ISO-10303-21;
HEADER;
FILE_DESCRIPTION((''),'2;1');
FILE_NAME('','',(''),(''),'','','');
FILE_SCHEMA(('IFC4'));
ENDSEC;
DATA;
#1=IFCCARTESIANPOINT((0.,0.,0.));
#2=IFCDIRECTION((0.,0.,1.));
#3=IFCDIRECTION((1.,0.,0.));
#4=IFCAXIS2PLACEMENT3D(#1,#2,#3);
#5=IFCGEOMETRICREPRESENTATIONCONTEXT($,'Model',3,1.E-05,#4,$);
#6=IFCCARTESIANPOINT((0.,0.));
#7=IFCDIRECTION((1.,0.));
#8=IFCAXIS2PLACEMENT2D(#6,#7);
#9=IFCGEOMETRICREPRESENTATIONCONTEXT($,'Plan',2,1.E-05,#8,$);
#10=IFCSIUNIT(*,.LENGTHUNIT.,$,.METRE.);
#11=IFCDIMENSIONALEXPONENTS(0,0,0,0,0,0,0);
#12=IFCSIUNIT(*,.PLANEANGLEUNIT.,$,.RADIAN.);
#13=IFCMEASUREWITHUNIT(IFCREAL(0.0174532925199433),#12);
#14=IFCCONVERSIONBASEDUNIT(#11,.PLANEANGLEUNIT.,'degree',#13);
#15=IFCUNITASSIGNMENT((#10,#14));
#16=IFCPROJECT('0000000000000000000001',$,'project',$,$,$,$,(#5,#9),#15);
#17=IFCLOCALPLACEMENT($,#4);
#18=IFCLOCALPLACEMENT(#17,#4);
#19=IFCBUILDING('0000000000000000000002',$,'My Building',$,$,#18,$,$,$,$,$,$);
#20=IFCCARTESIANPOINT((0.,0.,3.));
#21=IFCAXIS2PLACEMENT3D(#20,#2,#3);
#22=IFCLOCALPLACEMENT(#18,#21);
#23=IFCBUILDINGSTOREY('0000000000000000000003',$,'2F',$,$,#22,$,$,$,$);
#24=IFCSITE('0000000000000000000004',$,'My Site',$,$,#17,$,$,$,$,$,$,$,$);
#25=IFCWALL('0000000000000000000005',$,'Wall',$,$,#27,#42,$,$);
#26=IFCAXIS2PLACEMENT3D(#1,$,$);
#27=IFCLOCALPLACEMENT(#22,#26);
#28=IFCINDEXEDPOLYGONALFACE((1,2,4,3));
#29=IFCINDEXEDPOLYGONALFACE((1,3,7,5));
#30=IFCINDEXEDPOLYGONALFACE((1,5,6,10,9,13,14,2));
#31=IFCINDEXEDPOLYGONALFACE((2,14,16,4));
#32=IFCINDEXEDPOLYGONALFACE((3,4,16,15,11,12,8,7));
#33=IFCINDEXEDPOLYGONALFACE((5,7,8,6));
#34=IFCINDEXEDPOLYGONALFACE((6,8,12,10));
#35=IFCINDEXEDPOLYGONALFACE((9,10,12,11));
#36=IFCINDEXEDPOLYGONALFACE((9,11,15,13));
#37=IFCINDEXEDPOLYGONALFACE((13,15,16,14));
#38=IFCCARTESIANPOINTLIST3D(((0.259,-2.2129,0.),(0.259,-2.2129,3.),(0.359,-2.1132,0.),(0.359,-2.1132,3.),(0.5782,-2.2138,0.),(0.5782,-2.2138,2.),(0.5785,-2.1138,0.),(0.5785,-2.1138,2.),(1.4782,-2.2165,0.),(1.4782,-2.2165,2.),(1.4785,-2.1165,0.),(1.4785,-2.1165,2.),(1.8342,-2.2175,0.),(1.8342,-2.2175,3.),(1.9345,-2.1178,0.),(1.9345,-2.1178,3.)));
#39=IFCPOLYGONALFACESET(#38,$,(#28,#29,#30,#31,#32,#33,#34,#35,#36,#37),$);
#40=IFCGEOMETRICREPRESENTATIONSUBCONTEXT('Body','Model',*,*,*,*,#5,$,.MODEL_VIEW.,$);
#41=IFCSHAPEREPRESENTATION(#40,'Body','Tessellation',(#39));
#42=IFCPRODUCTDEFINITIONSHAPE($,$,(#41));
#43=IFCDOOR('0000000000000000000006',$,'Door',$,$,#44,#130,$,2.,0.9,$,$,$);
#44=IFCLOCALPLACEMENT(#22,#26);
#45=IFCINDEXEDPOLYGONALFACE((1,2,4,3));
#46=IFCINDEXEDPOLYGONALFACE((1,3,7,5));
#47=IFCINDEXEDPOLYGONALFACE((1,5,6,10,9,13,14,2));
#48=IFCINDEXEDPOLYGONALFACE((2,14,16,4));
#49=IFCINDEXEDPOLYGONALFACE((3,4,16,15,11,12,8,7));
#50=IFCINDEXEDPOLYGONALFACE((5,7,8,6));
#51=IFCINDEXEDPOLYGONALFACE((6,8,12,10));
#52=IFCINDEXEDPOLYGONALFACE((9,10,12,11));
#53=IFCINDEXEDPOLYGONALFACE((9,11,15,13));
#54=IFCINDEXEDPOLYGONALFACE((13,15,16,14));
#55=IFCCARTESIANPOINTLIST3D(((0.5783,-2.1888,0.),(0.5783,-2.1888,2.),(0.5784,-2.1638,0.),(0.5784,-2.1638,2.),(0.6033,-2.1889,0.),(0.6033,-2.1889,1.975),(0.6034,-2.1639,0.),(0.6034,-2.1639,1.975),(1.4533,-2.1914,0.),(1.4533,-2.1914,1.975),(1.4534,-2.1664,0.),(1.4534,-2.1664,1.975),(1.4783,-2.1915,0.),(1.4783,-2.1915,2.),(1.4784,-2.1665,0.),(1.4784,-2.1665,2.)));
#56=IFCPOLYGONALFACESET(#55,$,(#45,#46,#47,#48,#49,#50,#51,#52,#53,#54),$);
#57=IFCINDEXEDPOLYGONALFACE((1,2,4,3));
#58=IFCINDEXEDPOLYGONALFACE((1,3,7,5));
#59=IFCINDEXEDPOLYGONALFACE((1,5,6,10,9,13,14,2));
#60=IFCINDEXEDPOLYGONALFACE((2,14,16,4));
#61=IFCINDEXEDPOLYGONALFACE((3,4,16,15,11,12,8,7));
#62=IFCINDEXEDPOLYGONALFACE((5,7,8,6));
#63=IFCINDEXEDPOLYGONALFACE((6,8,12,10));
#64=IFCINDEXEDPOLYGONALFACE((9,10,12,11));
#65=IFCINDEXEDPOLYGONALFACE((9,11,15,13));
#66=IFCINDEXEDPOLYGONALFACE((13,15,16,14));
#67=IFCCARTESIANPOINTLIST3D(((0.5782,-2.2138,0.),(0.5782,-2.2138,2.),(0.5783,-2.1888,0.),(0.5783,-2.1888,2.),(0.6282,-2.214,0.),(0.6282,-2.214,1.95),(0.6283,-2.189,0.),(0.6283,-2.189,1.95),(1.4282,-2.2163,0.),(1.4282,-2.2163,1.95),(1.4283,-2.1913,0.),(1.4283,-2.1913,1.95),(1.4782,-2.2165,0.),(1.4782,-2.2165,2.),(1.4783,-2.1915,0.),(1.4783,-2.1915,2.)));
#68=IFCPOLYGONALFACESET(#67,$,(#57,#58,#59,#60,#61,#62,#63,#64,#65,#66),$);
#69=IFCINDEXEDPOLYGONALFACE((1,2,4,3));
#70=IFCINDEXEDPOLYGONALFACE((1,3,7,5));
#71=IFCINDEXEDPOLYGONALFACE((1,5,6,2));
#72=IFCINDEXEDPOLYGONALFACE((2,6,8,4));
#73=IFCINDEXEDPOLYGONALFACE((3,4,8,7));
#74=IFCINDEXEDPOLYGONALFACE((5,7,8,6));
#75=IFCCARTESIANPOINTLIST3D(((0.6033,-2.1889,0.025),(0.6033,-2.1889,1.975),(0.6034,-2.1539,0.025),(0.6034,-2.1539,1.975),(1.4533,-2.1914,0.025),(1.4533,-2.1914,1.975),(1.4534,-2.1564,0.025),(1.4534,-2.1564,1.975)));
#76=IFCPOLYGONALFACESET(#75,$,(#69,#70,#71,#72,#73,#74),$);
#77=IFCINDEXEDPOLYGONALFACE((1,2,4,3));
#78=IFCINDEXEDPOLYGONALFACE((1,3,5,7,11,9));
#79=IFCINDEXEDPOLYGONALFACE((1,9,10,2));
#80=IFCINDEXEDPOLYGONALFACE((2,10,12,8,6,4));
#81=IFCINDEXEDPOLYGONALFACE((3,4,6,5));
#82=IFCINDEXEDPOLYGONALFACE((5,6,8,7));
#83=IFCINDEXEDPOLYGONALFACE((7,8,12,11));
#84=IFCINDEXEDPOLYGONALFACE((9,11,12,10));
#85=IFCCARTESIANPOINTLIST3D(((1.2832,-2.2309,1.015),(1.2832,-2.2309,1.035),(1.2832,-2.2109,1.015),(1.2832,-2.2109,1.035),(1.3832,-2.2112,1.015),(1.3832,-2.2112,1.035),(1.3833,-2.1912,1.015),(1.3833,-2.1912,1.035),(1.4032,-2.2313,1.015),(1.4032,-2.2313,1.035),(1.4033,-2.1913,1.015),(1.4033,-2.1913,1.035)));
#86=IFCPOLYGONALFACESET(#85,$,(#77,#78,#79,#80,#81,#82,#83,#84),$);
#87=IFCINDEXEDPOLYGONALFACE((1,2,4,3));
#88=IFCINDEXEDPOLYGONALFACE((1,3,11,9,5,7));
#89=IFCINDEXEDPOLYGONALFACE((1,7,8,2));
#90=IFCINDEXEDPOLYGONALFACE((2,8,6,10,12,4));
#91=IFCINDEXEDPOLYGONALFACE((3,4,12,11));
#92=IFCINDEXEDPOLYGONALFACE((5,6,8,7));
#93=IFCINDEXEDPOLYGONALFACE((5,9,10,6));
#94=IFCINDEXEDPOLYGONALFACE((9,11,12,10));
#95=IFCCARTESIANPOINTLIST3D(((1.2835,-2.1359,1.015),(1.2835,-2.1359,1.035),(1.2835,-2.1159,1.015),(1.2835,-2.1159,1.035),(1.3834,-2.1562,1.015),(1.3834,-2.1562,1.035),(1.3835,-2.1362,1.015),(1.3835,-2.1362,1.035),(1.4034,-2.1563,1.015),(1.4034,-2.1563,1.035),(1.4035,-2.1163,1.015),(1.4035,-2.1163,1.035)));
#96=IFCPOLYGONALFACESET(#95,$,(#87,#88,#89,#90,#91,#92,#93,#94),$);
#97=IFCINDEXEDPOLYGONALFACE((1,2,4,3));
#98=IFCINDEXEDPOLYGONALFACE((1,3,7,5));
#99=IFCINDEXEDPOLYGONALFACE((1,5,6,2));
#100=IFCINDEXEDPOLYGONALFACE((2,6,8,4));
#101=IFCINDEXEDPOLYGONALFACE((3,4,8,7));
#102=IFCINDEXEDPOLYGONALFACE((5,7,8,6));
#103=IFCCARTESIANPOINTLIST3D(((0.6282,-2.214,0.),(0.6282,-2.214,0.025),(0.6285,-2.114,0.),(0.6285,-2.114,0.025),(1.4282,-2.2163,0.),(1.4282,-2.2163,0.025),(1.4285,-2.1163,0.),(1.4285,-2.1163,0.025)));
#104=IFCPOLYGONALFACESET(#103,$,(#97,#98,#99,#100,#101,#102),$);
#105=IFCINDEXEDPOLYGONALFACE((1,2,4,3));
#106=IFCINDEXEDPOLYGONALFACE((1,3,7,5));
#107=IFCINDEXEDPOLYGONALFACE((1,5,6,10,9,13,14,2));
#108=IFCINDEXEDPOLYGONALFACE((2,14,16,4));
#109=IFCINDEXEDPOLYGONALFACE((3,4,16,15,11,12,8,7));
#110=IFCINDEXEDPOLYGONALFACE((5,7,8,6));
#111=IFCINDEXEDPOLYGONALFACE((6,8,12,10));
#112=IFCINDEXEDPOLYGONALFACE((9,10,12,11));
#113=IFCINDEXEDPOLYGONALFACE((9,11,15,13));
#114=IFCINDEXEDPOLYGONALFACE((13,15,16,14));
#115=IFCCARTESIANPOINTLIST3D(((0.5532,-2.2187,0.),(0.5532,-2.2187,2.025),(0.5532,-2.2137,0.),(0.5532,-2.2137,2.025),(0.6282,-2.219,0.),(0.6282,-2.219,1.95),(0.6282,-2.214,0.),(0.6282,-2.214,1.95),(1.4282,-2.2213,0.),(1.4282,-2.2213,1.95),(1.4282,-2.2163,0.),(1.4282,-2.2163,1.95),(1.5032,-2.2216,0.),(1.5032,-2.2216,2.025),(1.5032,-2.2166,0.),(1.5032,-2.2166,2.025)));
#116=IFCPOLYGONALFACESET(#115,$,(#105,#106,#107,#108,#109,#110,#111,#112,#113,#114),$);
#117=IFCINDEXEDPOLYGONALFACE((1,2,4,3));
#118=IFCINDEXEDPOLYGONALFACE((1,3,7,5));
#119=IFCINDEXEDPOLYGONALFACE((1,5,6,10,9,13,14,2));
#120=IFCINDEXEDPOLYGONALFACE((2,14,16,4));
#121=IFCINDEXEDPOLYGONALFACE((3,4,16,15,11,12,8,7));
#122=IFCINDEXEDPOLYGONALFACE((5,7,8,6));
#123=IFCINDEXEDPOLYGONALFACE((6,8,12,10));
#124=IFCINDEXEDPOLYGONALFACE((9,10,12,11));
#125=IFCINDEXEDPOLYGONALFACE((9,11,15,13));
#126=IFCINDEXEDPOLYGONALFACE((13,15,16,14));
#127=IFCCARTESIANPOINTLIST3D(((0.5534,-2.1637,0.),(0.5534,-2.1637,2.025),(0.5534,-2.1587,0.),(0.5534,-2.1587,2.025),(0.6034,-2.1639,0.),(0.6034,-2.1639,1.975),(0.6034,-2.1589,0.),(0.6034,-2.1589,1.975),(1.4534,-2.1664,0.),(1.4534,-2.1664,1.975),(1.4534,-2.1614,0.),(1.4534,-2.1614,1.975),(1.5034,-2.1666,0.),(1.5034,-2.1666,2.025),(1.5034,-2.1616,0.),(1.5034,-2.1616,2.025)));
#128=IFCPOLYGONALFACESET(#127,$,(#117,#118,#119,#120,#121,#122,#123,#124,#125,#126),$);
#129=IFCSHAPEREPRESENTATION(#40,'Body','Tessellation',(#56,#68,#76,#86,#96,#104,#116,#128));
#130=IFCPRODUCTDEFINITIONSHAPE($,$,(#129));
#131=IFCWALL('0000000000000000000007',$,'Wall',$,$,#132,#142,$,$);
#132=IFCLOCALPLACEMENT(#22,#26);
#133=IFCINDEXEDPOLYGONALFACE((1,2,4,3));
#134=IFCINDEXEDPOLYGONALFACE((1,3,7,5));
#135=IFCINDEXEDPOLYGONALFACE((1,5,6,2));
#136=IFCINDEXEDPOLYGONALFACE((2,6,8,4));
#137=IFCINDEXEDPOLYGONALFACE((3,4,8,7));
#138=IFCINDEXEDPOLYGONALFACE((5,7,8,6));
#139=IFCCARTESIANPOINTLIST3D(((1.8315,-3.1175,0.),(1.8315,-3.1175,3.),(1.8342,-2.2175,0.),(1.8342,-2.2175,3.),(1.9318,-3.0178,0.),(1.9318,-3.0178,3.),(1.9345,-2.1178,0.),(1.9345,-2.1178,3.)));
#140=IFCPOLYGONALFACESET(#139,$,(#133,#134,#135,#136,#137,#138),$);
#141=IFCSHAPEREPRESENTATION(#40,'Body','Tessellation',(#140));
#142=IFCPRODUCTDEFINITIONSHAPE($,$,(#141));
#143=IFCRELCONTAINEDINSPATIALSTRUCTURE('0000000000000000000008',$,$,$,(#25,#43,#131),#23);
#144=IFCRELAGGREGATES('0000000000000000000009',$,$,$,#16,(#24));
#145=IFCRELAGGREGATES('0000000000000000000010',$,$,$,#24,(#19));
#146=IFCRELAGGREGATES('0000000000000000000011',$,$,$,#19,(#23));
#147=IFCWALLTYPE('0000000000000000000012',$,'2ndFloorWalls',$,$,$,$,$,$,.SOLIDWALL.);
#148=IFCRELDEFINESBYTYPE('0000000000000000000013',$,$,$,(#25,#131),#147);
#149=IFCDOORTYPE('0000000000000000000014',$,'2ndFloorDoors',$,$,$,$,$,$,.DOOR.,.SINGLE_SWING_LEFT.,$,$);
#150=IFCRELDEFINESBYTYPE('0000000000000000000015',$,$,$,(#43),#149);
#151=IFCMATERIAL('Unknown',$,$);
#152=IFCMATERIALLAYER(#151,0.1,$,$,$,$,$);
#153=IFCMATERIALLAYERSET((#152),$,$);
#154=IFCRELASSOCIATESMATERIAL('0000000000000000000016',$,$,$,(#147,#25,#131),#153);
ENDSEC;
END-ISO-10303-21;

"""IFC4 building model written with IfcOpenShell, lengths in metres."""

from ifc_helpers import new_model, entity, si_unit, converted_unit, frame, origin_with_axes, origin_2d_with_axis, place, context, subcontext, project, spatial, line, indexed_curve, outline, extrude, shape, source, transform, mapped, material, layer, layer_set, layer_usage, type_object, type_shapes, element, fill, save


model = new_model("IFC4")

# Units and contexts
model_context = context("Model", 3, precision=1e-05, world=origin_with_axes())
plan_context = context("Plan", 2, precision=1e-05, world=origin_2d_with_axis())
body_context_1 = subcontext(model_context, "Body", "Model", "MODEL_VIEW")
body_context_2 = subcontext(plan_context, "Body", "Plan", "PLAN_VIEW")
ifc_project = project(units=[si_unit("LENGTHUNIT", "METRE"), converted_unit("PLANEANGLEUNIT", "degree", entity("IfcReal", 0.0174532925199433), si_unit("PLANEANGLEUNIT", "RADIAN"), dimensions=[0, 0, 0, 0, 0, 0, 0])], contexts=[model_context, plan_context])

# Site, building, storey
site_placement = place(None, origin_with_axes())
site = spatial("IfcSite", under=ifc_project, at=site_placement, Name="My Site")
building_placement = place(site_placement, origin_with_axes())
building = spatial("IfcBuilding", under=site, at=building_placement, Name="My Building")
storey_placement = place(building_placement, frame((0.0, 0.0, 3.0), z_axis=(0.0, 0.0, 1.0), x_axis=(1.0, 0.0, 0.0)))
storey = spatial("IfcBuildingStorey", under=building, at=storey_placement, Name="2F")

# Shared definitions
ifc_material = material(Name="Unknown")

# Shared definitions
ifc_layer = layer(ifc_material, 0.1)
ifc_layer_set = layer_set([ifc_layer])
wall_type = type_object("IfcWallType", Name="2ndFloorWalls", PredefinedType="SOLIDWALL", material=ifc_layer_set)

# Wall, opening, door
ifc_layer_usage_1 = layer_usage(ifc_layer_set, "AXIS2", "POSITIVE", 0.0)
wall_1_placement = place(storey_placement, frame((0.259, -2.2129, 0.0), z_axis=(0.0, 0.0, 1.0), x_axis=(0.999996, -0.002967, 0.0)))
wall_1 = element("IfcWall", 1, at=wall_1_placement, inside=storey, type_object=wall_type, material=ifc_layer_usage_1, Name="Wall", context=body_context_1, shape_type="SweptSolid", body=[
    extrude(outline(indexed_curve([(0.0, 0.0), (0.0997, 0.1), (1.6752, 0.1), (1.5752, 0.0)], segments=[line(1, 2, 3, 4, 1)])), origin_with_axes(), (0.0, 0.0, 1.0), 3.0),
])
shared_shape_1 = source(origin_with_axes(), body_context_1, "Body", "SweptSolid", [
    extrude(outline(indexed_curve([(0.0, 0.0), (0.9, 0.0), (0.9, 2.0), (0.0, 2.0)], segments=[line(1, 2, 3, 4, 1)])), frame((0.0, -0.6, 0.0), z_axis=(0.0, -1.0, 0.0), x_axis=(1.0, 0.0, 0.0)), (0.0, 0.0, -1.0), 1.2),
])
opening_1_placement = place(wall_1_placement, frame((0.3192, 0.0, 0.0), z_axis=(0.0, 0.0, 1.0), x_axis=(1.0, 0.0, 0.0)))
opening_1 = element("IfcOpeningElement", 2, at=opening_1_placement, cuts=wall_1, PredefinedType="OPENING", context=body_context_1, shape_type="MappedRepresentation", body=[
    mapped(shared_shape_1, transform((0.0, 0.0, 0.0), x_axis=(1.0, 0.0, 0.0), y_axis=(0.0, 1.0, 0.0), z_axis=(0.0, 0.0, 1.0), scale=1.0)),
])
door_type = type_object("IfcDoorType", Name="2ndFloorDoors", OperationType="SINGLE_SWING_LEFT", PredefinedType="DOOR")
shared_shape_2 = source(origin_with_axes(), body_context_1, "Body", "SweptSolid", [
    extrude(outline(indexed_curve([(0.0, 0.0), (0.0, 2.0), (0.9, 2.0), (0.9, 0.0), (0.875, 0.0), (0.875, 1.975), (0.025, 1.975), (0.025, 0.0)], segments=[line(1, 2, 3, 4, 5, 6, 7, 8, 1)])), frame((0.0, 0.025, 0.0), z_axis=(0.0, -1.0, 0.0), x_axis=(1.0, 0.0, 0.0)), (0.0, 0.0, -1.0), 0.025),
    extrude(outline(indexed_curve([(0.0, 0.0), (0.0, 2.0), (0.9, 2.0), (0.9, 0.0), (0.85, 0.0), (0.85, 1.95), (0.05, 1.95), (0.05, 0.0)], segments=[line(1, 2, 3, 4, 5, 6, 7, 8, 1)])), frame((0.0, 0.0, 0.0), z_axis=(0.0, -1.0, 0.0), x_axis=(1.0, 0.0, 0.0)), (0.0, 0.0, -1.0), 0.025),
    extrude(outline(indexed_curve([(0.0, 0.0), (0.85, 0.0), (0.85, 0.035), (0.0, 0.035)], segments=[line(1, 2, 3, 4, 1)])), frame((0.025, 0.025, 0.025), z_axis=(0.0, 0.0, 1.0), x_axis=(1.0, 0.0, 0.0)), (0.0, 0.0, 1.0), 1.95),
    extrude(outline(indexed_curve([(0.0, 0.0), (0.0, -0.04), (-0.12, -0.04), (-0.12, -0.02), (-0.02, -0.02), (-0.02, 0.0)], segments=[line(1, 2, 3, 4, 5, 6, 1)])), frame((0.825, 0.025, 1.015), z_axis=(0.0, 0.0, 1.0), x_axis=(1.0, 0.0, 0.0)), (0.0, 0.0, 1.0), 0.02),
    extrude(outline(indexed_curve([(0.0, 0.0), (0.0, 0.04), (-0.12, 0.04), (-0.12, 0.02), (-0.02, 0.02), (-0.02, 0.0)], segments=[line(1, 2, 3, 4, 5, 6, 1)])), frame((0.825, 0.06, 1.015), z_axis=(0.0, 0.0, 1.0), x_axis=(1.0, 0.0, 0.0)), (0.0, 0.0, 1.0), 0.02),
    extrude(outline(indexed_curve([(0.0, 0.0), (0.8, 0.0), (0.8, 0.1), (0.0, 0.1)], segments=[line(1, 2, 3, 4, 1)])), frame((0.05, 0.0, 0.0), z_axis=(0.0, 0.0, 1.0), x_axis=(1.0, 0.0, 0.0)), (0.0, 0.0, 1.0), 0.025),
    extrude(outline(indexed_curve([(0.0, 0.0), (0.0, 2.025), (0.95, 2.025), (0.95, 0.0), (0.875, 0.0), (0.875, 1.95), (0.075, 1.95), (0.075, 0.0)], segments=[line(1, 2, 3, 4, 5, 6, 7, 8, 1)])), frame((-0.025, -0.005, 0.0), z_axis=(0.0, -1.0, 0.0), x_axis=(1.0, 0.0, 0.0)), (0.0, 0.0, -1.0), 0.005),
    extrude(outline(indexed_curve([(0.0, 0.0), (0.0, 2.025), (0.95, 2.025), (0.95, 0.0), (0.9, 0.0), (0.9, 1.975), (0.05, 1.975), (0.05, 0.0)], segments=[line(1, 2, 3, 4, 5, 6, 7, 8, 1)])), frame((-0.025, 0.05, 0.0), z_axis=(0.0, -1.0, 0.0), x_axis=(1.0, 0.0, 0.0)), (0.0, 0.0, -1.0), 0.005),
])
shared_shape_3 = source(origin_with_axes(), body_context_2, "Body", "Curve2D", [
    entity("IfcIndexedPolyCurve", entity("IfcCartesianPointList2D", [[0.0, 0.0], [0.0, 0.05], [0.025, 0.05], [0.025, 0.025], [0.05, 0.025], [0.05, 0.0]]), [entity("IfcLineIndex", [1, 2, 3, 4, 5, 6, 1])]),
    entity("IfcIndexedPolyCurve", entity("IfcCartesianPointList2D", [[0.9, 0.0], [0.9, 0.05], [0.875, 0.05], [0.875, 0.025], [0.85, 0.025], [0.85, 0.0]]), [entity("IfcLineIndex", [1, 2, 3, 4, 5, 6, 1])]),
    entity("IfcTrimmedCurve", entity("IfcEllipse", entity("IfcAxis2Placement2D", entity("IfcCartesianPoint", [0.06, 0.05]), entity("IfcDirection", [1.0, 0.0])), 0.815, 0.85), [entity("IfcCartesianPoint", [0.875, 0.05])], [entity("IfcCartesianPoint", [0.06, 0.9])], True, "CARTESIAN"),
    entity("IfcIndexedPolyCurve", entity("IfcCartesianPointList2D", [[0.025, 0.05], [0.06, 0.05], [0.06, 0.9], [0.025, 0.9]]), [entity("IfcLineIndex", [1, 2, 3, 4, 1])]),
])
type_shapes(door_type, [shared_shape_2, shared_shape_3])
door_1_placement = place(opening_1_placement, frame((0.0, 0.0, 0.0), z_axis=(0.0, 0.0, 1.0), x_axis=(1.0, 0.0, 0.0)))
door_1 = element("IfcDoor", 3, at=door_1_placement, inside=storey, type_object=door_type, Name="Door", OverallHeight=2.0, OverallWidth=0.9, shapes=[
    shape(body_context_1, "Body", "MappedRepresentation", [mapped(shared_shape_2, transform((0.0, 0.0, 0.0), x_axis=(1.0, 0.0, 0.0), y_axis=(0.0, 1.0, 0.0), z_axis=(0.0, 0.0, 1.0), scale=1.0))]),
    shape(body_context_2, "Body", "MappedRepresentation", [mapped(shared_shape_3, transform((0.0, 0.0, 0.0), x_axis=(1.0, 0.0, 0.0), y_axis=(0.0, 1.0, 0.0), z_axis=(0.0, 0.0, 1.0), scale=1.0))]),
])
fill(opening_1, door_1)

# Wall
ifc_layer_usage_2 = layer_usage(ifc_layer_set, "AXIS2", "POSITIVE", 0.0)
wall_2_placement = place(storey_placement, frame((1.8342, -2.2175, 0.0), z_axis=(0.0, 0.0, 1.0), x_axis=(-0.002967, -0.999996, 0.0)))
element("IfcWall", 4, at=wall_2_placement, inside=storey, type_object=wall_type, material=ifc_layer_usage_2, Name="Wall", context=body_context_1, shape_type="SweptSolid", body=[
    extrude(outline(indexed_curve([(0.0, 0.0), (-0.1, 0.1), (0.8, 0.1), (0.9, 0.0)], segments=[line(1, 2, 3, 4, 1)])), origin_with_axes(), (0.0, 0.0, 1.0), 3.0),
])

save(model, "model.ifc")
